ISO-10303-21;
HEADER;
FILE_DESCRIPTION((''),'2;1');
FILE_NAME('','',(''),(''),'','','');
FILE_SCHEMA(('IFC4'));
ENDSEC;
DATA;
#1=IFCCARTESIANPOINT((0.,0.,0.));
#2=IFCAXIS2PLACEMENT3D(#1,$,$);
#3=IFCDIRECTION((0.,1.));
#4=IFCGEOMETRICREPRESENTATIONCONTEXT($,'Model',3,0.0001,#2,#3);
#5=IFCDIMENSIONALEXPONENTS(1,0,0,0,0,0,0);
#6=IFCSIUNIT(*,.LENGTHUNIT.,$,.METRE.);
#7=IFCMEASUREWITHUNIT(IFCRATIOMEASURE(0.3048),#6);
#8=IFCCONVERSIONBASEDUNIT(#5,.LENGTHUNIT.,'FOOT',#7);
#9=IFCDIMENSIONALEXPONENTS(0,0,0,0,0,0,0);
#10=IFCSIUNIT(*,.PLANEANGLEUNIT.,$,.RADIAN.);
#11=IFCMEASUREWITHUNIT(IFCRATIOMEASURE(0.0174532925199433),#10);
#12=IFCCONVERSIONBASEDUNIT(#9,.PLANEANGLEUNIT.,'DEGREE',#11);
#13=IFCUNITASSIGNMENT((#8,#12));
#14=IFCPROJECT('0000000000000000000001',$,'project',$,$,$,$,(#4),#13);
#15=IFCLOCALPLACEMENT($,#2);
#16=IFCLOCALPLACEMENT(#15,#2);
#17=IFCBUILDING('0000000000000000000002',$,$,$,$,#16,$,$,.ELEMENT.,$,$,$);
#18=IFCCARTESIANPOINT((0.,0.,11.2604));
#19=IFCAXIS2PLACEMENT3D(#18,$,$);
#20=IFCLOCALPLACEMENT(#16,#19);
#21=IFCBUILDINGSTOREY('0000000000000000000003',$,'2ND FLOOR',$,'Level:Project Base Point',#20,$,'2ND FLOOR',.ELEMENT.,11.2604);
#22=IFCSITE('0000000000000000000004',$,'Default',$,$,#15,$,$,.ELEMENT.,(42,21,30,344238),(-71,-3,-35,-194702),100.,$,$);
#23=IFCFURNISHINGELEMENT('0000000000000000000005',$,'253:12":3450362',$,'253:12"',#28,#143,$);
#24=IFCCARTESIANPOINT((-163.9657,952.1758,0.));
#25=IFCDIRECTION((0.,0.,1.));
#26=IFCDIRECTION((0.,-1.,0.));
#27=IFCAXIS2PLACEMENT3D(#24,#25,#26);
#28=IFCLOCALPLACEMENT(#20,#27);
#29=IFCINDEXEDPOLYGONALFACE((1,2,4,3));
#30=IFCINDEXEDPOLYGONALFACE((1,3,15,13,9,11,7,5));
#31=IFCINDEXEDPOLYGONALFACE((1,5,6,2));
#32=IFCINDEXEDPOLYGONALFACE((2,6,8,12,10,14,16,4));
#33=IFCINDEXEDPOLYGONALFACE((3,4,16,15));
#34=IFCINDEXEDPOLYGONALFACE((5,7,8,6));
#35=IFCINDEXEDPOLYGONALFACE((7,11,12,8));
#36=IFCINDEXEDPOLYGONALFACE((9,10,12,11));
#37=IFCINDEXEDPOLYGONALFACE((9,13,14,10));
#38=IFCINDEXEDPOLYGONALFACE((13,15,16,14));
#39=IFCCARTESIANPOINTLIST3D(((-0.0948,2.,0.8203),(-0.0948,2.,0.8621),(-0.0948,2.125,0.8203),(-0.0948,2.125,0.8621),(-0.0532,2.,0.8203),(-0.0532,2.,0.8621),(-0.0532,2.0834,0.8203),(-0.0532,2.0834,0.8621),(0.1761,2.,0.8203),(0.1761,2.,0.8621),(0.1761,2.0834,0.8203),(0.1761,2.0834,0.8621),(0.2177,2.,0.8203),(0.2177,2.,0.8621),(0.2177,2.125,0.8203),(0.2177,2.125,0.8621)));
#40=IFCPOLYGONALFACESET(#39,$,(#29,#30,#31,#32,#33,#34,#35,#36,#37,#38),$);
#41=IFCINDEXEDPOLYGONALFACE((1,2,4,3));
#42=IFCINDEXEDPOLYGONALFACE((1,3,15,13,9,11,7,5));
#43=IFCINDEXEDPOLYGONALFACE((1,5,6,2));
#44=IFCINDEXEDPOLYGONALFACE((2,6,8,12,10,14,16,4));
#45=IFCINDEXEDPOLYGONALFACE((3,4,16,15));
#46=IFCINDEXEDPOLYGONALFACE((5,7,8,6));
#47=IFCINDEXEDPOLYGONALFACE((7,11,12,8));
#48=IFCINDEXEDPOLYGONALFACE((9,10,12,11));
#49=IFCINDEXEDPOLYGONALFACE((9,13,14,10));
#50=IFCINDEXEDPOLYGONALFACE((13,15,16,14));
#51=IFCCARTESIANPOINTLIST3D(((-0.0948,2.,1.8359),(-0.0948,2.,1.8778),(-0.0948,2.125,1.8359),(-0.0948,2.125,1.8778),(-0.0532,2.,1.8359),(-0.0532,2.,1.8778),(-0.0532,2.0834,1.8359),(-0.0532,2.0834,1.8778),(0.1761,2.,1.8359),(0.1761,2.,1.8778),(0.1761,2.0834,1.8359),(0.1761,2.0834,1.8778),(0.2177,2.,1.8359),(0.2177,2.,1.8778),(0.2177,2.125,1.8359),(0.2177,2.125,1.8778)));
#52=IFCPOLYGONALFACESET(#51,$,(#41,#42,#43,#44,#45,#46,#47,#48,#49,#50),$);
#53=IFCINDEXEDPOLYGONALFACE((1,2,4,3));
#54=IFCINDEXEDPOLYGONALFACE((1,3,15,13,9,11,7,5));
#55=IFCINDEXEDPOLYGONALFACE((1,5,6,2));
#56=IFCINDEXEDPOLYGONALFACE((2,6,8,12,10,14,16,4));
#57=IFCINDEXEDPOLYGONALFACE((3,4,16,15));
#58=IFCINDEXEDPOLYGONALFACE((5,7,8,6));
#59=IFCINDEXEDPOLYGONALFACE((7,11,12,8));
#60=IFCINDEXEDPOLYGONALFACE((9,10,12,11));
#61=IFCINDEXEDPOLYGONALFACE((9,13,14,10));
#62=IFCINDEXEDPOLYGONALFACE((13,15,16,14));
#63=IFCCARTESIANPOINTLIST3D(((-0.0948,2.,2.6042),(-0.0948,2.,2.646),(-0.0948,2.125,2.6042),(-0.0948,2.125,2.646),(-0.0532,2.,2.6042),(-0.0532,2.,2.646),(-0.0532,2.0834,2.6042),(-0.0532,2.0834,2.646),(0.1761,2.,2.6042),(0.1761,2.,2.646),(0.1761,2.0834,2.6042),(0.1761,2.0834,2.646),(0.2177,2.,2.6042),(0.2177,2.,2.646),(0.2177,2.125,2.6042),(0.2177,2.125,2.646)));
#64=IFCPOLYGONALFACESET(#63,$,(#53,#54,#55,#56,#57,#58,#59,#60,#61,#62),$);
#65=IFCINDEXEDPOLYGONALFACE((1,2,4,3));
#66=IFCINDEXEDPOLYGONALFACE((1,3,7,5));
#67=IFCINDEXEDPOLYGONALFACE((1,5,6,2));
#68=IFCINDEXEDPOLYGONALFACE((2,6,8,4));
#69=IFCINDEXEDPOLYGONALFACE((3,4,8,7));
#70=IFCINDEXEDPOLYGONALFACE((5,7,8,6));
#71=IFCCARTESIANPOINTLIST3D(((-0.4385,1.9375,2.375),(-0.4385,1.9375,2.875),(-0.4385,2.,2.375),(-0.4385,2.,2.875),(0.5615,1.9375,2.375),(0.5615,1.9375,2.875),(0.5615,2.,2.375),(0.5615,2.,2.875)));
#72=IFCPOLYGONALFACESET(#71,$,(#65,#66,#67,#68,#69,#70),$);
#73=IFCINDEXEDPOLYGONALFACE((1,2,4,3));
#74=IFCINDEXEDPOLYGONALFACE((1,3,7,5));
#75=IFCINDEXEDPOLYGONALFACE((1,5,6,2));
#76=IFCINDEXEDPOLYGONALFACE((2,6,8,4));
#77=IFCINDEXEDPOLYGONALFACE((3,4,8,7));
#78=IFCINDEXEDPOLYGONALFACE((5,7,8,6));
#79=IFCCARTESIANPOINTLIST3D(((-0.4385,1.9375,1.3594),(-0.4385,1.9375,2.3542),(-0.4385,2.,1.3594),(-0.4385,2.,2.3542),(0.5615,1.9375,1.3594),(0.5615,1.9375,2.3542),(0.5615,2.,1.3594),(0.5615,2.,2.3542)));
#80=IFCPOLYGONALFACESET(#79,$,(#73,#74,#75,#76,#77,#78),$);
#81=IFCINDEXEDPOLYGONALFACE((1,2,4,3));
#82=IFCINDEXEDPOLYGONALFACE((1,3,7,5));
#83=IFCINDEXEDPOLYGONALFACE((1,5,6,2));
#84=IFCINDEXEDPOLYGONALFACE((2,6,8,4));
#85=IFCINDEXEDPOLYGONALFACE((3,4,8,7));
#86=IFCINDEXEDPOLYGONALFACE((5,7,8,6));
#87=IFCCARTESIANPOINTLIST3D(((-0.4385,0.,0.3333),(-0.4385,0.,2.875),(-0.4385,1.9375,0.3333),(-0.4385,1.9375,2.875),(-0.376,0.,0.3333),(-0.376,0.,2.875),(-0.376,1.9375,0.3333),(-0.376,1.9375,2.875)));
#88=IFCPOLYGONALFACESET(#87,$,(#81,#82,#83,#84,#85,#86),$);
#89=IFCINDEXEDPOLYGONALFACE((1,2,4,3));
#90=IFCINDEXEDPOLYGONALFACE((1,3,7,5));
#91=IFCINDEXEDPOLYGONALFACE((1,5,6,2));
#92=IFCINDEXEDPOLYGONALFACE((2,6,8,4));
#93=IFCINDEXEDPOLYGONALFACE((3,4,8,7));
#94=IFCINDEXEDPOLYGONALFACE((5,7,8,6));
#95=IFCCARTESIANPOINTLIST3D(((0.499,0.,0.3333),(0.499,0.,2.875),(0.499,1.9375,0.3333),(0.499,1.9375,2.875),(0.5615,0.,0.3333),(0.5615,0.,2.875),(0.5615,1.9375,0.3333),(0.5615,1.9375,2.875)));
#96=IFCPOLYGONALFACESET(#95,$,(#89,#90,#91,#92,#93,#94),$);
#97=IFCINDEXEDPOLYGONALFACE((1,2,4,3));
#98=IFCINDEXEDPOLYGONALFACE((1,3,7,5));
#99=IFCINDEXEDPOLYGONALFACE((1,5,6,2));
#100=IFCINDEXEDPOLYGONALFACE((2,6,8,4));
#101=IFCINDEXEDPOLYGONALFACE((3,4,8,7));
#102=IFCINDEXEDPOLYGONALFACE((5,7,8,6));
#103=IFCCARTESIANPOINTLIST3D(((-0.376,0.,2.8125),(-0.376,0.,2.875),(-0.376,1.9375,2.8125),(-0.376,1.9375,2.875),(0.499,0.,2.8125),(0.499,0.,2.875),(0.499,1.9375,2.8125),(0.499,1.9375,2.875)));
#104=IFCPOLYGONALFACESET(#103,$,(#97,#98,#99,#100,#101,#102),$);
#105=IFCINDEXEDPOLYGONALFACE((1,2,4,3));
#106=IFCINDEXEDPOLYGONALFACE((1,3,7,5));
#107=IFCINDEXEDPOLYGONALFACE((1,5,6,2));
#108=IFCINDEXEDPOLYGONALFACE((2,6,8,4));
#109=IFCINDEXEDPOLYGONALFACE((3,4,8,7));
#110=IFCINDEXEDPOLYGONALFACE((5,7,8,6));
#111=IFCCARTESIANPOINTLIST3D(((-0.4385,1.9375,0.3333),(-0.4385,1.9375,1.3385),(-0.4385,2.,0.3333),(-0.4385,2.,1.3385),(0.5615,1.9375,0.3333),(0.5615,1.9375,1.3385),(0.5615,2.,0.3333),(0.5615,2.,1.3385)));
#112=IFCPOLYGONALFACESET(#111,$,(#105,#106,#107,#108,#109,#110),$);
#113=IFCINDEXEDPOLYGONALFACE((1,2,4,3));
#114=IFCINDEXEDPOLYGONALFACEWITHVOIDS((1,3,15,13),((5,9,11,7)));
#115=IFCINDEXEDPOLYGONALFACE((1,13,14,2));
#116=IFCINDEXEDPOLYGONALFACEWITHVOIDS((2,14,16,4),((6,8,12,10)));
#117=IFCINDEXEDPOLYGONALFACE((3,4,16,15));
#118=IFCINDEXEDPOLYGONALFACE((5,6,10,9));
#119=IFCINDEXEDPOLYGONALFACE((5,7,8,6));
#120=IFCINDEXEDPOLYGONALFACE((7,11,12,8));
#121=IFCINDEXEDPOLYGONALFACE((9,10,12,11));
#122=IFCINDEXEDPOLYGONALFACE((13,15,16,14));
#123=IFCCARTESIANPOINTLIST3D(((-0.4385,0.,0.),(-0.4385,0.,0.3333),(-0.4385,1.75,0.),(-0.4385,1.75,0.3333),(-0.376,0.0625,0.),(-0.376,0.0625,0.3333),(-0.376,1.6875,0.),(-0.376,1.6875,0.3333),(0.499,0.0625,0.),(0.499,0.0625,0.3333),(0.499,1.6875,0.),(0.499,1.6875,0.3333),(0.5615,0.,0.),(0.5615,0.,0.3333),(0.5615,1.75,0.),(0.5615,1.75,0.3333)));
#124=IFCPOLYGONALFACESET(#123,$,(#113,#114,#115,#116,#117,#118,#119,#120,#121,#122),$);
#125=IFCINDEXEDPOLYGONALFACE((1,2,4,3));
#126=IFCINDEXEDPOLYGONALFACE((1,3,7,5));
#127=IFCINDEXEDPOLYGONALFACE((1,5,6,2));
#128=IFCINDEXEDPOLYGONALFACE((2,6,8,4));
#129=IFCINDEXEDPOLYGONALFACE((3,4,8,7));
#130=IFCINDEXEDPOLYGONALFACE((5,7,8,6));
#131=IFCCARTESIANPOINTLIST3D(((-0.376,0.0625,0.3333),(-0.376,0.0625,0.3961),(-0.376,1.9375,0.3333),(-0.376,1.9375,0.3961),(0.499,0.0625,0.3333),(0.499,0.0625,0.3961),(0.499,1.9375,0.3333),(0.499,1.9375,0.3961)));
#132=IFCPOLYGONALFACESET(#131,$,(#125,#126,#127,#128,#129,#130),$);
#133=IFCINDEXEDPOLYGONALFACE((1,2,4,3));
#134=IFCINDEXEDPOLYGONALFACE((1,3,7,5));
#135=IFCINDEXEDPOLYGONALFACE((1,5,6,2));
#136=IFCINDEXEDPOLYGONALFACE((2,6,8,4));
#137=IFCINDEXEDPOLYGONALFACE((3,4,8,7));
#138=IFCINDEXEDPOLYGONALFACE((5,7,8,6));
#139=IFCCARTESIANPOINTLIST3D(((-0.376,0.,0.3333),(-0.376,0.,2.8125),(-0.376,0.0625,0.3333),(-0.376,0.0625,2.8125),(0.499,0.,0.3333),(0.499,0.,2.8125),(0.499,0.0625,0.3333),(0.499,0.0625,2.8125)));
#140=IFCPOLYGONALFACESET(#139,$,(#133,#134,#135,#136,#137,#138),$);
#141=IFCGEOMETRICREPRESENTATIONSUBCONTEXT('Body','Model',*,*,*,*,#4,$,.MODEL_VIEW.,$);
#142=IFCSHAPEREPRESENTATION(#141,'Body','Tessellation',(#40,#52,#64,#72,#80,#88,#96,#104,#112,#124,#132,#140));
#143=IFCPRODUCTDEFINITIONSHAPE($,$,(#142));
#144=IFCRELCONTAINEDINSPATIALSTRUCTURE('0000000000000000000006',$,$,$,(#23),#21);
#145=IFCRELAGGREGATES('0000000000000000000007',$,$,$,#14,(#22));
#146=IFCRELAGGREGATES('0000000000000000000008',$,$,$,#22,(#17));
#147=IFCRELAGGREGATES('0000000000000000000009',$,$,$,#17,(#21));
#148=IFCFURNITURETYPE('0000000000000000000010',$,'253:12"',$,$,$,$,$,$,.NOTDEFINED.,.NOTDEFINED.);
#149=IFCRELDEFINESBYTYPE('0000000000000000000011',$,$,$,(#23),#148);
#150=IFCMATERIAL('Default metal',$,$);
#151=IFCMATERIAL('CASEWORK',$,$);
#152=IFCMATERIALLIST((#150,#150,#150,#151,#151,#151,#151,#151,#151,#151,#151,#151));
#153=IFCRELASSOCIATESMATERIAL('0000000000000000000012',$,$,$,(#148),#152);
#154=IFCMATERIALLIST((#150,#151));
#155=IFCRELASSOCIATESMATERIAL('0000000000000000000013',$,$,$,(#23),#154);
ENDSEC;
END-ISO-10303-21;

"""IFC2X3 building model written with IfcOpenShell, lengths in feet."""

from ifc_helpers import new_model, entity, si_unit, converted_unit, direction, frame, frame_2d, origin, origin_2d_with_axis, place, context, subcontext, project, spatial, polyline, rectangle, outline, extrude, source, transform, mapped, material, material_list, type_object, type_shapes, element, save


model = new_model("IFC2X3")

# Units and contexts
model_context = context("Model", 3, precision=0.0001, world=origin(), true_north=direction((0.0, 1.0)))
body_context = subcontext(model_context, "Body", "Model", "MODEL_VIEW")
ifc_project = project(units=[converted_unit("LENGTHUNIT", "FOOT", entity("IfcRatioMeasure", 0.3048), si_unit("LENGTHUNIT", "METRE"), dimensions=[1, 0, 0, 0, 0, 0, 0]), converted_unit("PLANEANGLEUNIT", "DEGREE", entity("IfcRatioMeasure", 0.0174532925199433), si_unit("PLANEANGLEUNIT", "RADIAN"), dimensions=[0, 0, 0, 0, 0, 0, 0])], contexts=[model_context])

# Site, building, storey
site_placement = place(None, origin())
site = spatial("IfcSite", under=ifc_project, at=site_placement, Name="Default", CompositionType="ELEMENT", RefLatitude=(42, 21, 30, 344238), RefLongitude=(-71, -3, -35, -194702), RefElevation=100.0)
building_placement = place(site_placement, origin())
building = spatial("IfcBuilding", under=site, at=building_placement, CompositionType="ELEMENT")
storey_placement = place(building_placement, frame((0.0, 0.0, 11.2604)))
storey = spatial("IfcBuildingStorey", under=building, at=storey_placement, Name="2ND FLOOR", ObjectType="Level:Project Base Point", LongName="2ND FLOOR", CompositionType="ELEMENT", Elevation=11.2604)

# Furnishing element
ifc_material_1 = material(Name="CASEWORK")
ifc_material_2 = material(Name="Default metal")
ifc_material_list_1 = material_list([ifc_material_2, ifc_material_1])
ifc_material_list_2 = material_list([ifc_material_2, ifc_material_2, ifc_material_2, ifc_material_1, ifc_material_1, ifc_material_1, ifc_material_1, ifc_material_1, ifc_material_1, ifc_material_1, ifc_material_1, ifc_material_1])
furniture_type_1 = type_object("IfcFurnitureType", Name="253:12\"", material=ifc_material_list_2)
shared_shape_1 = source(origin(), body_context, "Body", "SweptSolid", [
    extrude(outline(polyline([(-0.1562, -0.0521), (-0.1146, -0.0521), (-0.1146, 0.0313), (0.1146, 0.0313), (0.1146, -0.0521), (0.1562, -0.0521), (0.1562, 0.0729), (-0.1562, 0.0729), (-0.1562, -0.0521)])), frame((0.0615, 2.0521, 0.8203)), (0.0, 0.0, 1.0), 0.0418),
    extrude(outline(polyline([(-0.1562, -0.0521), (-0.1146, -0.0521), (-0.1146, 0.0313), (0.1146, 0.0313), (0.1146, -0.0521), (0.1562, -0.0521), (0.1562, 0.0729), (-0.1562, 0.0729), (-0.1562, -0.0521)])), frame((0.0615, 2.0521, 1.8359)), (0.0, 0.0, 1.0), 0.0418),
    extrude(outline(polyline([(-0.1562, -0.0521), (-0.1146, -0.0521), (-0.1146, 0.0313), (0.1146, 0.0313), (0.1146, -0.0521), (0.1562, -0.0521), (0.1562, 0.0729), (-0.1562, 0.0729), (-0.1562, -0.0521)])), frame((0.0615, 2.0521, 2.6042)), (0.0, 0.0, 1.0), 0.0418),
    extrude(rectangle(XDim=1.0, YDim=0.0625, at=frame_2d((0.0, 0.0), x_axis=(1.0, 0.0))), frame((0.0615, 1.9688, 2.375), z_axis=(0.0, 0.0, 1.0), x_axis=(-1.0, 0.0, 0.0)), (0.0, 0.0, 1.0), 0.5),
    extrude(rectangle(XDim=1.0, YDim=0.0625, at=frame_2d((0.0, 0.0), x_axis=(1.0, 0.0))), frame((0.0615, 1.9688, 1.3594), z_axis=(0.0, 0.0, 1.0), x_axis=(-1.0, 0.0, 0.0)), (0.0, 0.0, 1.0), 0.9948),
    extrude(rectangle(XDim=1.9375, YDim=0.0625, at=frame_2d((0.0, 0.0), x_axis=(1.0, 0.0))), frame((-0.4073, 0.9687, 0.3333), z_axis=(0.0, 0.0, 1.0), x_axis=(0.0, -1.0, 0.0)), (0.0, 0.0, 1.0), 2.5417),
    extrude(rectangle(XDim=1.9375, YDim=0.0625, at=frame_2d((0.0, 0.0), x_axis=(1.0, 0.0))), frame((0.5302, 0.9687, 0.3333), z_axis=(0.0, 0.0, 1.0), x_axis=(0.0, -1.0, 0.0)), (0.0, 0.0, 1.0), 2.5417),
    extrude(rectangle(XDim=1.9375, YDim=0.875, at=origin_2d_with_axis()), frame((0.0615, 0.9688, 2.8125), z_axis=(0.0, 0.0, 1.0), x_axis=(0.0, 1.0, 0.0)), (0.0, 0.0, 1.0), 0.0625),
    extrude(rectangle(XDim=1.0, YDim=0.0625, at=frame_2d((0.0, 0.0), x_axis=(1.0, 0.0))), frame((0.0615, 1.9688, 0.3333), z_axis=(0.0, 0.0, 1.0), x_axis=(-1.0, 0.0, 0.0)), (0.0, 0.0, 1.0), 1.0052),
    extrude(outline(polyline([(-0.875, -0.5), (0.875, -0.5), (0.875, 0.5), (-0.875, 0.5), (-0.875, -0.5)]), holes=[polyline([(-0.8125, -0.4375), (-0.8125, 0.4375), (0.8125, 0.4375), (0.8125, -0.4375), (-0.8125, -0.4375)])]), frame((0.0615, 0.875, 0.0), z_axis=(0.0, 0.0, 1.0), x_axis=(0.0, -1.0, 0.0)), (0.0, 0.0, 1.0), 0.3333),
    extrude(rectangle(XDim=1.875, YDim=0.875, at=origin_2d_with_axis()), frame((0.0615, 1.0, 0.3333), z_axis=(0.0, 0.0, 1.0), x_axis=(0.0, 1.0, 0.0)), (0.0, 0.0, 1.0), 0.0627),
    extrude(rectangle(XDim=0.875, YDim=0.0625, at=origin_2d_with_axis()), frame((0.0615, 0.0312, 0.3333), z_axis=(0.0, 0.0, 1.0), x_axis=(-1.0, 0.0, 0.0)), (0.0, 0.0, 1.0), 2.4792),
])
type_shapes(furniture_type_1, [shared_shape_1])
furnishing_1_placement = place(storey_placement, frame((-163.9657, 952.1758, 0.0), z_axis=(0.0, 0.0, 1.0), x_axis=(0.0, -1.0, 0.0)))
element("IfcFurnishingElement", 1, at=furnishing_1_placement, inside=storey, type_object=furniture_type_1, material=ifc_material_list_1, Name="253:12\":3450362", ObjectType="253:12\"", context=body_context, shape_type="MappedRepresentation", body=[
    mapped(shared_shape_1, transform((0.0, 0.0, 0.0), scale=1.0)),
])

save(model, "model.ifc")
